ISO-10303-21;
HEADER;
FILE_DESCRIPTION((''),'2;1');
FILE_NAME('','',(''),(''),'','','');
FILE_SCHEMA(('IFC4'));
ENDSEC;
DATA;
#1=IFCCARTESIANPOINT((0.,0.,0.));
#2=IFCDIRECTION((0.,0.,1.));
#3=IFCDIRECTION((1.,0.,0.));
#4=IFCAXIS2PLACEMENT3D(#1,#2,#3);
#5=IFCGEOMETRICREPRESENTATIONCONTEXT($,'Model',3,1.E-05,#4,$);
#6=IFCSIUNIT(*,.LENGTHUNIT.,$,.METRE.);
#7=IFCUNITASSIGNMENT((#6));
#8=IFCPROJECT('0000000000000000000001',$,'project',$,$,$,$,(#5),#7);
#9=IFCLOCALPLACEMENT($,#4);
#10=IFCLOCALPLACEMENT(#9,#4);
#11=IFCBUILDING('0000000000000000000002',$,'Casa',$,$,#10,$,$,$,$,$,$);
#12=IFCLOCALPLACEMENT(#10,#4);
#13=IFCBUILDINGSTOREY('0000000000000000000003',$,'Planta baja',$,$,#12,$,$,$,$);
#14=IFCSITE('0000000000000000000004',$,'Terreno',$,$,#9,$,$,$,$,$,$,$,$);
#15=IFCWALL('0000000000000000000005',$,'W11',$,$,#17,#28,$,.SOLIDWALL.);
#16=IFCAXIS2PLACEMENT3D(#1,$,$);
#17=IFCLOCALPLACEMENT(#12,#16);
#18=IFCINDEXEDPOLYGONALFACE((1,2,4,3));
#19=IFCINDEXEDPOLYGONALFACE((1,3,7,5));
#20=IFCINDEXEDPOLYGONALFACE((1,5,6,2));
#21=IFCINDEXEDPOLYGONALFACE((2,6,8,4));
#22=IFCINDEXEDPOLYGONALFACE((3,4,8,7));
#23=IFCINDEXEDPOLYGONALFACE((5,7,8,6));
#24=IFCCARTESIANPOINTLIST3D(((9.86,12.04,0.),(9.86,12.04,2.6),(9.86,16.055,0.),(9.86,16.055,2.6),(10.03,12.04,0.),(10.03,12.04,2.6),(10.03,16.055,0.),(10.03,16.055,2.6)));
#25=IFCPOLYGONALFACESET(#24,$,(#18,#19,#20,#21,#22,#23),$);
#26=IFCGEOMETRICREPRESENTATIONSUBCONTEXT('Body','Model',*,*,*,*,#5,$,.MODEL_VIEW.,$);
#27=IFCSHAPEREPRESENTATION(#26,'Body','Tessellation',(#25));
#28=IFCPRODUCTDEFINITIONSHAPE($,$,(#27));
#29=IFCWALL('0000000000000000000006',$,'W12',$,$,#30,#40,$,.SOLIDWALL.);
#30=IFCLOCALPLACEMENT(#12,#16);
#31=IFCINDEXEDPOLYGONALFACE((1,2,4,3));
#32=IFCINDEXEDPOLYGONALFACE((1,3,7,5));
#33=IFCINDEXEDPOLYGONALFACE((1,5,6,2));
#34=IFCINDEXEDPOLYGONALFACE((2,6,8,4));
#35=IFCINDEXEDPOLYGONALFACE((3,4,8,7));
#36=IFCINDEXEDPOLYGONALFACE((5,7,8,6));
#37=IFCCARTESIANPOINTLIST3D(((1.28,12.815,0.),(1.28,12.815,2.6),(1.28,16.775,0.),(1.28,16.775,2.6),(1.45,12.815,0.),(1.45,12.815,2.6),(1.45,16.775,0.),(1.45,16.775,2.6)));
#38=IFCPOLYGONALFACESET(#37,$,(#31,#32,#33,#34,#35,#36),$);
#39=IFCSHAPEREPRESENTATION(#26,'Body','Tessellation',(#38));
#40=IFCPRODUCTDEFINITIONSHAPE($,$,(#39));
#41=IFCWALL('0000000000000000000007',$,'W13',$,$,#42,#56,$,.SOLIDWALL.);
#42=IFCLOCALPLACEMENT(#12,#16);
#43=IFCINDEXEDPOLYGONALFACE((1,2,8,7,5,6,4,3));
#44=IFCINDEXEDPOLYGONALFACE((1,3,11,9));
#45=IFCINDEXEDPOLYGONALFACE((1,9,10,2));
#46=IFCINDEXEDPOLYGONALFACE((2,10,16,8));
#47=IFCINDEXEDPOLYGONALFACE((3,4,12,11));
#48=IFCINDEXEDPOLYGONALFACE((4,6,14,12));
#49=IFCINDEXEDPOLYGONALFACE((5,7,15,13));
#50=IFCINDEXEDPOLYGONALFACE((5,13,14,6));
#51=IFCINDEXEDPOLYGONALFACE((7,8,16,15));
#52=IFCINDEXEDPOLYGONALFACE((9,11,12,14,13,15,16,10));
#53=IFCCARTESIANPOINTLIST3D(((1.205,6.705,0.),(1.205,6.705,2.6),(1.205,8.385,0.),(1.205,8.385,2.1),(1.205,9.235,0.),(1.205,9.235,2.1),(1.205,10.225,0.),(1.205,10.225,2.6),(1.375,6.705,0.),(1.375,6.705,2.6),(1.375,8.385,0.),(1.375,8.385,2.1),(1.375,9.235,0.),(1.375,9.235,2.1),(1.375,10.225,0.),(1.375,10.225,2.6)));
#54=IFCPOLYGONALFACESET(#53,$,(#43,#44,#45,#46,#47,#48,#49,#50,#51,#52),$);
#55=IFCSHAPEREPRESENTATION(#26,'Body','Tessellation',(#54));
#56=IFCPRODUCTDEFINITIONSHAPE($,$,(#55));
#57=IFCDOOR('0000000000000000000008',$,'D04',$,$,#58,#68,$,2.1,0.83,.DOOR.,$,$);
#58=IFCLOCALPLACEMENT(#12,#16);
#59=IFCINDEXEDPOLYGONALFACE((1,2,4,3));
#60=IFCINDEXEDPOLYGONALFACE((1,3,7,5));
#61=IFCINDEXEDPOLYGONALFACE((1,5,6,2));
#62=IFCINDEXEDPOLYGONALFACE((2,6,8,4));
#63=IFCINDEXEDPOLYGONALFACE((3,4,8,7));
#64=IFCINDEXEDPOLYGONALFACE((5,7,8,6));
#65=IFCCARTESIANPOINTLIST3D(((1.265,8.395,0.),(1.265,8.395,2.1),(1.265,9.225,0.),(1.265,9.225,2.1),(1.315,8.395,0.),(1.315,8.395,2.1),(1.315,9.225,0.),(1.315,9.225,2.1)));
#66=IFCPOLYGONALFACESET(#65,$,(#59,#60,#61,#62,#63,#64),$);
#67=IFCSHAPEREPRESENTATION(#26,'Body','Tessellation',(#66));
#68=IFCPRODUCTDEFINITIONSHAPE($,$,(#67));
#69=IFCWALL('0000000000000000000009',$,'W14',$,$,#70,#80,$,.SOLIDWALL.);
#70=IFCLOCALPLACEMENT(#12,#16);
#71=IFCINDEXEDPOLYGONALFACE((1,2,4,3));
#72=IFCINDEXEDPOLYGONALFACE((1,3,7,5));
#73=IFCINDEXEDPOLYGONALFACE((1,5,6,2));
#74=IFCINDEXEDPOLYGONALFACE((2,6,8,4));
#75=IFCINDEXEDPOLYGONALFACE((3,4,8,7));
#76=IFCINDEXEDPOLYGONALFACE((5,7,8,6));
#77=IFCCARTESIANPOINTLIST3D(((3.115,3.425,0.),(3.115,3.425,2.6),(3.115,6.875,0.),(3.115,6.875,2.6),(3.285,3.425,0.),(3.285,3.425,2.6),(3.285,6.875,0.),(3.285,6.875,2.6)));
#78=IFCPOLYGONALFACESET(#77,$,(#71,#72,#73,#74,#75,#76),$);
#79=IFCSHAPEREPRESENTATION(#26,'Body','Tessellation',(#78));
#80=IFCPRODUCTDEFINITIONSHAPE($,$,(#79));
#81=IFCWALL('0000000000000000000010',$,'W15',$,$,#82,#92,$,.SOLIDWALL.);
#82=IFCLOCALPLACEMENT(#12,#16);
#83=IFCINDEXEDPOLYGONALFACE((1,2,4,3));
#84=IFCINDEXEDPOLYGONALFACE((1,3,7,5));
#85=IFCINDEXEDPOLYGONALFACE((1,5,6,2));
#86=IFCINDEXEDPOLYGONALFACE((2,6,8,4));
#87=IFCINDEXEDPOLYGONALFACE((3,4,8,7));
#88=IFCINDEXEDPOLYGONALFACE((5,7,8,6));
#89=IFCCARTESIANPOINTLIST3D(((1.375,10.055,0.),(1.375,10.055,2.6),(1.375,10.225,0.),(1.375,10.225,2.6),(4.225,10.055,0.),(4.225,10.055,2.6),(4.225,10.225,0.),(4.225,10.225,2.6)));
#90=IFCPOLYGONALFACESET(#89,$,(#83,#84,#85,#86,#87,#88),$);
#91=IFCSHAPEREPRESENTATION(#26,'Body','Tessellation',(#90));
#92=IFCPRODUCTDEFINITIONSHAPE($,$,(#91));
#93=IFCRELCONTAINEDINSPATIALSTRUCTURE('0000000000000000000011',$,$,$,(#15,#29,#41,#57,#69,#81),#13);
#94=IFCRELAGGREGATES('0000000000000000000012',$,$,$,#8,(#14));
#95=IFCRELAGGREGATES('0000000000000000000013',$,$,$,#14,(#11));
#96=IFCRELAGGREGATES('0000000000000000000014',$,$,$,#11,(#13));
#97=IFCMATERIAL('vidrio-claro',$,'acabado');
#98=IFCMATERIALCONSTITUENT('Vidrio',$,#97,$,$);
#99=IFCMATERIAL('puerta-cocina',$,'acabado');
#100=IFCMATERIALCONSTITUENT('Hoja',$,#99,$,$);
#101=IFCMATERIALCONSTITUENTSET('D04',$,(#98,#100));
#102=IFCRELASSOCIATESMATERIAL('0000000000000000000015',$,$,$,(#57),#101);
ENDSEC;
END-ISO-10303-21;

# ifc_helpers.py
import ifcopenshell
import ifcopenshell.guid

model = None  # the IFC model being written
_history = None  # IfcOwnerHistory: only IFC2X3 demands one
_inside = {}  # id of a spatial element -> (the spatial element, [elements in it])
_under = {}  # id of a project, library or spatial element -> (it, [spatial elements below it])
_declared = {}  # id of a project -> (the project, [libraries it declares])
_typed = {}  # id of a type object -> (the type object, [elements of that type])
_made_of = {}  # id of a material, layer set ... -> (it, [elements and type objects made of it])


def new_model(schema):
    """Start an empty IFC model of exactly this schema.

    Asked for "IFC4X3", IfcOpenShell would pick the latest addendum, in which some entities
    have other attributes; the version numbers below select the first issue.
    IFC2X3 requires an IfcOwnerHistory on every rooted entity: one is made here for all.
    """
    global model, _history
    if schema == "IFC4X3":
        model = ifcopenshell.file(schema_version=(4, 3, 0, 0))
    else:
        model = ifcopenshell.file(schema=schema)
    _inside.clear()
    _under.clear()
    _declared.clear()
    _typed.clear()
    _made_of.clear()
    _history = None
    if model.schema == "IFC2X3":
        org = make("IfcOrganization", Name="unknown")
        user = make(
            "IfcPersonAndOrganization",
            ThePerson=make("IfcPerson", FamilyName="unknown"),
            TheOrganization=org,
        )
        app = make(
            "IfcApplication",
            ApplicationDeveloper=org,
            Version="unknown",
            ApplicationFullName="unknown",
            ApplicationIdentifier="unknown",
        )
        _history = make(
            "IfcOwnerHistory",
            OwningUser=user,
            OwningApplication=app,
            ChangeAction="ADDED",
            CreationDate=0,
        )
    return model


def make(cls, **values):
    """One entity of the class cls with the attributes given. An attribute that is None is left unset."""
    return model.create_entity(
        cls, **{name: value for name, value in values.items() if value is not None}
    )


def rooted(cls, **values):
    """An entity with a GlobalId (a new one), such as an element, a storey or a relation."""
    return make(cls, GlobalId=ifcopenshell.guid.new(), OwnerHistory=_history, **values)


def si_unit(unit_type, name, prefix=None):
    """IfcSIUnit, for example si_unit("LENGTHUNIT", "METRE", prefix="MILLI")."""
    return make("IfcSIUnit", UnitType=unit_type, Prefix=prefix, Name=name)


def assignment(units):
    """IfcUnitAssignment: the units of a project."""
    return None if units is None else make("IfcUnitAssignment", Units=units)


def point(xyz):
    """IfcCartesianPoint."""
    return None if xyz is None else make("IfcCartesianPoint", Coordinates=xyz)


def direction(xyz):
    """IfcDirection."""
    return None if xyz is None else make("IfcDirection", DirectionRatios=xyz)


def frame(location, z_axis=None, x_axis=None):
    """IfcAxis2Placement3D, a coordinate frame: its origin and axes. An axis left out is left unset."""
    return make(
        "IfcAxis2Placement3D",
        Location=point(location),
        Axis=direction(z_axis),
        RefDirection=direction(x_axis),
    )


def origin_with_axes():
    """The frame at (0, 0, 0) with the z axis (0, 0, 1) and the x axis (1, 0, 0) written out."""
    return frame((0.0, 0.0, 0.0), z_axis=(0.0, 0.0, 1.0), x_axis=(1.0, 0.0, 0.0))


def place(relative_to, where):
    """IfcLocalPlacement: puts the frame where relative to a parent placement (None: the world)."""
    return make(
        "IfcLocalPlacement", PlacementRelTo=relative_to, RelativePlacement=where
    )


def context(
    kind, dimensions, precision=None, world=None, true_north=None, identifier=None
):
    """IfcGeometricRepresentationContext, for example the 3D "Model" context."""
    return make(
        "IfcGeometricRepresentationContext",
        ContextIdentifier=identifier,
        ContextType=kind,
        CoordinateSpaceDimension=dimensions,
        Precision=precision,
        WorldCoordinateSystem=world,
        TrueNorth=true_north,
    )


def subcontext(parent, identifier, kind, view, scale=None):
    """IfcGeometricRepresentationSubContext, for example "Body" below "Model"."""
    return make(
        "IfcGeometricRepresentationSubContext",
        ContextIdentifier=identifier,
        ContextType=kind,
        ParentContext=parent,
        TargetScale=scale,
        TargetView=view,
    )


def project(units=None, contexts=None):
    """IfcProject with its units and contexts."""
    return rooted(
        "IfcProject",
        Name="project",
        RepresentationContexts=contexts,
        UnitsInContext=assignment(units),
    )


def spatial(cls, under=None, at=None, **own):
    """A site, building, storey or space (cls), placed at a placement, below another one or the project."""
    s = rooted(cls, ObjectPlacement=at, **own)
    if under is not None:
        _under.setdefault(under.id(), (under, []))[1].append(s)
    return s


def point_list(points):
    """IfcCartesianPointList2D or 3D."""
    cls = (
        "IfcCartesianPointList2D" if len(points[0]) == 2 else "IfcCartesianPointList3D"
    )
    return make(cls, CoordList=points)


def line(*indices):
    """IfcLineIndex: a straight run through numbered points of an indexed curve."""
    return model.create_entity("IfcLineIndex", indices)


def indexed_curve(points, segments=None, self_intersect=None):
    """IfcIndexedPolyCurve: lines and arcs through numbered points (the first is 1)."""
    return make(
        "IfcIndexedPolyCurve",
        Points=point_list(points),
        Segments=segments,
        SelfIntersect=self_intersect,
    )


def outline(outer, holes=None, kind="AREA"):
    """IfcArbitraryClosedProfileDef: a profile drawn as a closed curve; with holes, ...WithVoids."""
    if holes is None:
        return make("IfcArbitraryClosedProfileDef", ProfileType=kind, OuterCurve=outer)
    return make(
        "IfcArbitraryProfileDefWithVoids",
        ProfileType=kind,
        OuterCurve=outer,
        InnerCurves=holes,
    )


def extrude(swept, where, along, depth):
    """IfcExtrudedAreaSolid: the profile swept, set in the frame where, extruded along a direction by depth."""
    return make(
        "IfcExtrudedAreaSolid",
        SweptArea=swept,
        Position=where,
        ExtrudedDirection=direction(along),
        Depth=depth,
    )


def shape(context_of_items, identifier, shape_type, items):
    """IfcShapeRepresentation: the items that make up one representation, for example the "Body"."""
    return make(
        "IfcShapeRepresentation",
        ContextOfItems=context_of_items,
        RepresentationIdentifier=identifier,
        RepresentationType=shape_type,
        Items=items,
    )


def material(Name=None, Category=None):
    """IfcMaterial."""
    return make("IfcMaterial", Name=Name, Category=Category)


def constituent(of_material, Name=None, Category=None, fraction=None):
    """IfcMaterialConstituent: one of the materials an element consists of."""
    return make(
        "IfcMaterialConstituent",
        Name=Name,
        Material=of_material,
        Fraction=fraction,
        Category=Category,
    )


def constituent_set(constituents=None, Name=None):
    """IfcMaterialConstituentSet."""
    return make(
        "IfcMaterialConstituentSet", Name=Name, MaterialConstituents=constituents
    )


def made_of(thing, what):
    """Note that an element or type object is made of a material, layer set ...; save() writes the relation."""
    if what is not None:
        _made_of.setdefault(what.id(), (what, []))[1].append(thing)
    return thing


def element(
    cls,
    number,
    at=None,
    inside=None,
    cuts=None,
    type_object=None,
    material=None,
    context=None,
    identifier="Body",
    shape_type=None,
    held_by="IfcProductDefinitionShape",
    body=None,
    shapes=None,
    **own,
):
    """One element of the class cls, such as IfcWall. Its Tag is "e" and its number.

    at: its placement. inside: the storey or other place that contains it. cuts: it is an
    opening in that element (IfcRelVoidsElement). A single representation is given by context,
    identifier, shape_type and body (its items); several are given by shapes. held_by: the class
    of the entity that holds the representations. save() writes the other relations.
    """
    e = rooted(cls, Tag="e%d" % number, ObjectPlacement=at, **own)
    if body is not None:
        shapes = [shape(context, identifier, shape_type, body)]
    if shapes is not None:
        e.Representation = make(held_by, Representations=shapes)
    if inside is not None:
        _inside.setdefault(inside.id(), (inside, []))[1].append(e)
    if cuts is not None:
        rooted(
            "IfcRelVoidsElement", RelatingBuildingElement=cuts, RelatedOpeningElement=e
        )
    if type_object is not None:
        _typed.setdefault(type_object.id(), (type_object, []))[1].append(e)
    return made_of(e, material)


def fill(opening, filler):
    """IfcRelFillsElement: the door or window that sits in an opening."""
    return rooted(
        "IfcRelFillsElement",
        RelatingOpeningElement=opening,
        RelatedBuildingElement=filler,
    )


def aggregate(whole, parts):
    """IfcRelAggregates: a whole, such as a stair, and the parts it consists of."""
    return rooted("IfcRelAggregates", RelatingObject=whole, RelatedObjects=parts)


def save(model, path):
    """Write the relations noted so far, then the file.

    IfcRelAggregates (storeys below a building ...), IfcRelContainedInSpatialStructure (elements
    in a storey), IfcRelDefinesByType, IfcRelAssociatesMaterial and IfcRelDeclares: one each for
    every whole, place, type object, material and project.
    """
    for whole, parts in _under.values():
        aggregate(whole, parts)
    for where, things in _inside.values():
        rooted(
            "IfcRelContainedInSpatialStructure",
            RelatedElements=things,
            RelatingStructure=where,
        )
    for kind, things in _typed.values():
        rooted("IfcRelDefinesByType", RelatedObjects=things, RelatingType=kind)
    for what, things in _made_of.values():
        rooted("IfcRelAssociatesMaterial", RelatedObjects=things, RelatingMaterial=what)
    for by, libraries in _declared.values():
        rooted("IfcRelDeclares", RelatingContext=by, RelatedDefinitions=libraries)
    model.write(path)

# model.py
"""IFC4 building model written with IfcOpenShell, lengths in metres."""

from ifc_helpers import new_model, si_unit, origin_with_axes, place, context, subcontext, project, spatial, line, indexed_curve, outline, extrude, material, constituent, constituent_set, element, fill, save


model = new_model("IFC4")

# Units and contexts
model_context = context("Model", 3, precision=1e-05, world=origin_with_axes())
body_context = subcontext(model_context, "Body", "Model", "MODEL_VIEW")
ifc_project = project(units=[si_unit("LENGTHUNIT", "METRE")], contexts=[model_context])

# Site, building, storey
site_placement = place(None, origin_with_axes())
site = spatial("IfcSite", under=ifc_project, at=site_placement, Name="Terreno")
building_placement = place(site_placement, origin_with_axes())
building = spatial("IfcBuilding", under=site, at=building_placement, Name="Casa")
storey_placement = place(building_placement, origin_with_axes())
storey = spatial("IfcBuildingStorey", under=building, at=storey_placement, Name="Planta baja")

# Shared definitions
ifc_material_1 = material(Name="vidrio-claro", Category="acabado")

# Walls
wall_1_placement = place(storey_placement, origin_with_axes())
element("IfcWall", 1, at=wall_1_placement, inside=storey, Name="W11", PredefinedType="SOLIDWALL", context=body_context, shape_type="SweptSolid", body=[
    extrude(outline(indexed_curve([(9.86, 12.04), (9.86, 16.055), (10.03, 16.055), (10.03, 12.04)], segments=[line(1, 2, 3, 4, 1)])), origin_with_axes(), (0.0, 0.0, 1.0), 2.6),
])
wall_2_placement = place(storey_placement, origin_with_axes())
element("IfcWall", 2, at=wall_2_placement, inside=storey, Name="W12", PredefinedType="SOLIDWALL", context=body_context, shape_type="SweptSolid", body=[
    extrude(outline(indexed_curve([(1.28, 16.775), (1.45, 16.775), (1.45, 12.815), (1.28, 12.815)], segments=[line(1, 2, 3, 4, 1)])), origin_with_axes(), (0.0, 0.0, 1.0), 2.6),
])

# Wall, opening, door
wall_3_placement = place(storey_placement, origin_with_axes())
wall_3 = element("IfcWall", 3, at=wall_3_placement, inside=storey, Name="W13", PredefinedType="SOLIDWALL", context=body_context, shape_type="SweptSolid", body=[
    extrude(outline(indexed_curve([(1.375, 6.705), (1.205, 6.705), (1.205, 10.225), (1.375, 10.225)], segments=[line(1, 2, 3, 4, 1)])), origin_with_axes(), (0.0, 0.0, 1.0), 2.6),
])
opening_1_placement = place(wall_3_placement, origin_with_axes())
opening_1 = element("IfcOpeningElement", 4, at=opening_1_placement, cuts=wall_3, PredefinedType="OPENING", context=body_context, shape_type="SweptSolid", body=[
    extrude(outline(indexed_curve([(1.195, 8.385), (1.195, 9.235), (1.385, 9.235), (1.385, 8.385)], segments=[line(1, 2, 3, 4, 1)])), origin_with_axes(), (0.0, 0.0, 1.0), 2.1),
])
ifc_constituent_1 = constituent(ifc_material_1, Name="Vidrio")
ifc_material_2 = material(Name="puerta-cocina", Category="acabado")
ifc_constituent_2 = constituent(ifc_material_2, Name="Hoja")
ifc_constituent_set_1 = constituent_set(constituents=[ifc_constituent_1, ifc_constituent_2], Name="D04")
door_1_placement = place(opening_1_placement, origin_with_axes())
door_1 = element("IfcDoor", 5, at=door_1_placement, inside=storey, material=ifc_constituent_set_1, Name="D04", OverallHeight=2.1, OverallWidth=0.83, PredefinedType="DOOR", context=body_context, shape_type="SweptSolid", body=[
    extrude(outline(indexed_curve([(1.265, 8.395), (1.265, 9.225), (1.315, 9.225), (1.315, 8.395)], segments=[line(1, 2, 3, 4, 1)])), origin_with_axes(), (0.0, 0.0, 1.0), 2.1),
])
fill(opening_1, door_1)

# Walls
wall_4_placement = place(storey_placement, origin_with_axes())
element("IfcWall", 6, at=wall_4_placement, inside=storey, Name="W14", PredefinedType="SOLIDWALL", context=body_context, shape_type="SweptSolid", body=[
    extrude(outline(indexed_curve([(3.285, 3.425), (3.115, 3.425), (3.115, 6.875), (3.285, 6.875)], segments=[line(1, 2, 3, 4, 1)])), origin_with_axes(), (0.0, 0.0, 1.0), 2.6),
])
wall_5_placement = place(storey_placement, origin_with_axes())
element("IfcWall", 7, at=wall_5_placement, inside=storey, Name="W15", PredefinedType="SOLIDWALL", context=body_context, shape_type="SweptSolid", body=[
    extrude(outline(indexed_curve([(4.225, 10.225), (4.225, 10.055), (1.375, 10.055), (1.375, 10.225)], segments=[line(1, 2, 3, 4, 1)])), origin_with_axes(), (0.0, 0.0, 1.0), 2.6),
])

save(model, "model.ifc")
